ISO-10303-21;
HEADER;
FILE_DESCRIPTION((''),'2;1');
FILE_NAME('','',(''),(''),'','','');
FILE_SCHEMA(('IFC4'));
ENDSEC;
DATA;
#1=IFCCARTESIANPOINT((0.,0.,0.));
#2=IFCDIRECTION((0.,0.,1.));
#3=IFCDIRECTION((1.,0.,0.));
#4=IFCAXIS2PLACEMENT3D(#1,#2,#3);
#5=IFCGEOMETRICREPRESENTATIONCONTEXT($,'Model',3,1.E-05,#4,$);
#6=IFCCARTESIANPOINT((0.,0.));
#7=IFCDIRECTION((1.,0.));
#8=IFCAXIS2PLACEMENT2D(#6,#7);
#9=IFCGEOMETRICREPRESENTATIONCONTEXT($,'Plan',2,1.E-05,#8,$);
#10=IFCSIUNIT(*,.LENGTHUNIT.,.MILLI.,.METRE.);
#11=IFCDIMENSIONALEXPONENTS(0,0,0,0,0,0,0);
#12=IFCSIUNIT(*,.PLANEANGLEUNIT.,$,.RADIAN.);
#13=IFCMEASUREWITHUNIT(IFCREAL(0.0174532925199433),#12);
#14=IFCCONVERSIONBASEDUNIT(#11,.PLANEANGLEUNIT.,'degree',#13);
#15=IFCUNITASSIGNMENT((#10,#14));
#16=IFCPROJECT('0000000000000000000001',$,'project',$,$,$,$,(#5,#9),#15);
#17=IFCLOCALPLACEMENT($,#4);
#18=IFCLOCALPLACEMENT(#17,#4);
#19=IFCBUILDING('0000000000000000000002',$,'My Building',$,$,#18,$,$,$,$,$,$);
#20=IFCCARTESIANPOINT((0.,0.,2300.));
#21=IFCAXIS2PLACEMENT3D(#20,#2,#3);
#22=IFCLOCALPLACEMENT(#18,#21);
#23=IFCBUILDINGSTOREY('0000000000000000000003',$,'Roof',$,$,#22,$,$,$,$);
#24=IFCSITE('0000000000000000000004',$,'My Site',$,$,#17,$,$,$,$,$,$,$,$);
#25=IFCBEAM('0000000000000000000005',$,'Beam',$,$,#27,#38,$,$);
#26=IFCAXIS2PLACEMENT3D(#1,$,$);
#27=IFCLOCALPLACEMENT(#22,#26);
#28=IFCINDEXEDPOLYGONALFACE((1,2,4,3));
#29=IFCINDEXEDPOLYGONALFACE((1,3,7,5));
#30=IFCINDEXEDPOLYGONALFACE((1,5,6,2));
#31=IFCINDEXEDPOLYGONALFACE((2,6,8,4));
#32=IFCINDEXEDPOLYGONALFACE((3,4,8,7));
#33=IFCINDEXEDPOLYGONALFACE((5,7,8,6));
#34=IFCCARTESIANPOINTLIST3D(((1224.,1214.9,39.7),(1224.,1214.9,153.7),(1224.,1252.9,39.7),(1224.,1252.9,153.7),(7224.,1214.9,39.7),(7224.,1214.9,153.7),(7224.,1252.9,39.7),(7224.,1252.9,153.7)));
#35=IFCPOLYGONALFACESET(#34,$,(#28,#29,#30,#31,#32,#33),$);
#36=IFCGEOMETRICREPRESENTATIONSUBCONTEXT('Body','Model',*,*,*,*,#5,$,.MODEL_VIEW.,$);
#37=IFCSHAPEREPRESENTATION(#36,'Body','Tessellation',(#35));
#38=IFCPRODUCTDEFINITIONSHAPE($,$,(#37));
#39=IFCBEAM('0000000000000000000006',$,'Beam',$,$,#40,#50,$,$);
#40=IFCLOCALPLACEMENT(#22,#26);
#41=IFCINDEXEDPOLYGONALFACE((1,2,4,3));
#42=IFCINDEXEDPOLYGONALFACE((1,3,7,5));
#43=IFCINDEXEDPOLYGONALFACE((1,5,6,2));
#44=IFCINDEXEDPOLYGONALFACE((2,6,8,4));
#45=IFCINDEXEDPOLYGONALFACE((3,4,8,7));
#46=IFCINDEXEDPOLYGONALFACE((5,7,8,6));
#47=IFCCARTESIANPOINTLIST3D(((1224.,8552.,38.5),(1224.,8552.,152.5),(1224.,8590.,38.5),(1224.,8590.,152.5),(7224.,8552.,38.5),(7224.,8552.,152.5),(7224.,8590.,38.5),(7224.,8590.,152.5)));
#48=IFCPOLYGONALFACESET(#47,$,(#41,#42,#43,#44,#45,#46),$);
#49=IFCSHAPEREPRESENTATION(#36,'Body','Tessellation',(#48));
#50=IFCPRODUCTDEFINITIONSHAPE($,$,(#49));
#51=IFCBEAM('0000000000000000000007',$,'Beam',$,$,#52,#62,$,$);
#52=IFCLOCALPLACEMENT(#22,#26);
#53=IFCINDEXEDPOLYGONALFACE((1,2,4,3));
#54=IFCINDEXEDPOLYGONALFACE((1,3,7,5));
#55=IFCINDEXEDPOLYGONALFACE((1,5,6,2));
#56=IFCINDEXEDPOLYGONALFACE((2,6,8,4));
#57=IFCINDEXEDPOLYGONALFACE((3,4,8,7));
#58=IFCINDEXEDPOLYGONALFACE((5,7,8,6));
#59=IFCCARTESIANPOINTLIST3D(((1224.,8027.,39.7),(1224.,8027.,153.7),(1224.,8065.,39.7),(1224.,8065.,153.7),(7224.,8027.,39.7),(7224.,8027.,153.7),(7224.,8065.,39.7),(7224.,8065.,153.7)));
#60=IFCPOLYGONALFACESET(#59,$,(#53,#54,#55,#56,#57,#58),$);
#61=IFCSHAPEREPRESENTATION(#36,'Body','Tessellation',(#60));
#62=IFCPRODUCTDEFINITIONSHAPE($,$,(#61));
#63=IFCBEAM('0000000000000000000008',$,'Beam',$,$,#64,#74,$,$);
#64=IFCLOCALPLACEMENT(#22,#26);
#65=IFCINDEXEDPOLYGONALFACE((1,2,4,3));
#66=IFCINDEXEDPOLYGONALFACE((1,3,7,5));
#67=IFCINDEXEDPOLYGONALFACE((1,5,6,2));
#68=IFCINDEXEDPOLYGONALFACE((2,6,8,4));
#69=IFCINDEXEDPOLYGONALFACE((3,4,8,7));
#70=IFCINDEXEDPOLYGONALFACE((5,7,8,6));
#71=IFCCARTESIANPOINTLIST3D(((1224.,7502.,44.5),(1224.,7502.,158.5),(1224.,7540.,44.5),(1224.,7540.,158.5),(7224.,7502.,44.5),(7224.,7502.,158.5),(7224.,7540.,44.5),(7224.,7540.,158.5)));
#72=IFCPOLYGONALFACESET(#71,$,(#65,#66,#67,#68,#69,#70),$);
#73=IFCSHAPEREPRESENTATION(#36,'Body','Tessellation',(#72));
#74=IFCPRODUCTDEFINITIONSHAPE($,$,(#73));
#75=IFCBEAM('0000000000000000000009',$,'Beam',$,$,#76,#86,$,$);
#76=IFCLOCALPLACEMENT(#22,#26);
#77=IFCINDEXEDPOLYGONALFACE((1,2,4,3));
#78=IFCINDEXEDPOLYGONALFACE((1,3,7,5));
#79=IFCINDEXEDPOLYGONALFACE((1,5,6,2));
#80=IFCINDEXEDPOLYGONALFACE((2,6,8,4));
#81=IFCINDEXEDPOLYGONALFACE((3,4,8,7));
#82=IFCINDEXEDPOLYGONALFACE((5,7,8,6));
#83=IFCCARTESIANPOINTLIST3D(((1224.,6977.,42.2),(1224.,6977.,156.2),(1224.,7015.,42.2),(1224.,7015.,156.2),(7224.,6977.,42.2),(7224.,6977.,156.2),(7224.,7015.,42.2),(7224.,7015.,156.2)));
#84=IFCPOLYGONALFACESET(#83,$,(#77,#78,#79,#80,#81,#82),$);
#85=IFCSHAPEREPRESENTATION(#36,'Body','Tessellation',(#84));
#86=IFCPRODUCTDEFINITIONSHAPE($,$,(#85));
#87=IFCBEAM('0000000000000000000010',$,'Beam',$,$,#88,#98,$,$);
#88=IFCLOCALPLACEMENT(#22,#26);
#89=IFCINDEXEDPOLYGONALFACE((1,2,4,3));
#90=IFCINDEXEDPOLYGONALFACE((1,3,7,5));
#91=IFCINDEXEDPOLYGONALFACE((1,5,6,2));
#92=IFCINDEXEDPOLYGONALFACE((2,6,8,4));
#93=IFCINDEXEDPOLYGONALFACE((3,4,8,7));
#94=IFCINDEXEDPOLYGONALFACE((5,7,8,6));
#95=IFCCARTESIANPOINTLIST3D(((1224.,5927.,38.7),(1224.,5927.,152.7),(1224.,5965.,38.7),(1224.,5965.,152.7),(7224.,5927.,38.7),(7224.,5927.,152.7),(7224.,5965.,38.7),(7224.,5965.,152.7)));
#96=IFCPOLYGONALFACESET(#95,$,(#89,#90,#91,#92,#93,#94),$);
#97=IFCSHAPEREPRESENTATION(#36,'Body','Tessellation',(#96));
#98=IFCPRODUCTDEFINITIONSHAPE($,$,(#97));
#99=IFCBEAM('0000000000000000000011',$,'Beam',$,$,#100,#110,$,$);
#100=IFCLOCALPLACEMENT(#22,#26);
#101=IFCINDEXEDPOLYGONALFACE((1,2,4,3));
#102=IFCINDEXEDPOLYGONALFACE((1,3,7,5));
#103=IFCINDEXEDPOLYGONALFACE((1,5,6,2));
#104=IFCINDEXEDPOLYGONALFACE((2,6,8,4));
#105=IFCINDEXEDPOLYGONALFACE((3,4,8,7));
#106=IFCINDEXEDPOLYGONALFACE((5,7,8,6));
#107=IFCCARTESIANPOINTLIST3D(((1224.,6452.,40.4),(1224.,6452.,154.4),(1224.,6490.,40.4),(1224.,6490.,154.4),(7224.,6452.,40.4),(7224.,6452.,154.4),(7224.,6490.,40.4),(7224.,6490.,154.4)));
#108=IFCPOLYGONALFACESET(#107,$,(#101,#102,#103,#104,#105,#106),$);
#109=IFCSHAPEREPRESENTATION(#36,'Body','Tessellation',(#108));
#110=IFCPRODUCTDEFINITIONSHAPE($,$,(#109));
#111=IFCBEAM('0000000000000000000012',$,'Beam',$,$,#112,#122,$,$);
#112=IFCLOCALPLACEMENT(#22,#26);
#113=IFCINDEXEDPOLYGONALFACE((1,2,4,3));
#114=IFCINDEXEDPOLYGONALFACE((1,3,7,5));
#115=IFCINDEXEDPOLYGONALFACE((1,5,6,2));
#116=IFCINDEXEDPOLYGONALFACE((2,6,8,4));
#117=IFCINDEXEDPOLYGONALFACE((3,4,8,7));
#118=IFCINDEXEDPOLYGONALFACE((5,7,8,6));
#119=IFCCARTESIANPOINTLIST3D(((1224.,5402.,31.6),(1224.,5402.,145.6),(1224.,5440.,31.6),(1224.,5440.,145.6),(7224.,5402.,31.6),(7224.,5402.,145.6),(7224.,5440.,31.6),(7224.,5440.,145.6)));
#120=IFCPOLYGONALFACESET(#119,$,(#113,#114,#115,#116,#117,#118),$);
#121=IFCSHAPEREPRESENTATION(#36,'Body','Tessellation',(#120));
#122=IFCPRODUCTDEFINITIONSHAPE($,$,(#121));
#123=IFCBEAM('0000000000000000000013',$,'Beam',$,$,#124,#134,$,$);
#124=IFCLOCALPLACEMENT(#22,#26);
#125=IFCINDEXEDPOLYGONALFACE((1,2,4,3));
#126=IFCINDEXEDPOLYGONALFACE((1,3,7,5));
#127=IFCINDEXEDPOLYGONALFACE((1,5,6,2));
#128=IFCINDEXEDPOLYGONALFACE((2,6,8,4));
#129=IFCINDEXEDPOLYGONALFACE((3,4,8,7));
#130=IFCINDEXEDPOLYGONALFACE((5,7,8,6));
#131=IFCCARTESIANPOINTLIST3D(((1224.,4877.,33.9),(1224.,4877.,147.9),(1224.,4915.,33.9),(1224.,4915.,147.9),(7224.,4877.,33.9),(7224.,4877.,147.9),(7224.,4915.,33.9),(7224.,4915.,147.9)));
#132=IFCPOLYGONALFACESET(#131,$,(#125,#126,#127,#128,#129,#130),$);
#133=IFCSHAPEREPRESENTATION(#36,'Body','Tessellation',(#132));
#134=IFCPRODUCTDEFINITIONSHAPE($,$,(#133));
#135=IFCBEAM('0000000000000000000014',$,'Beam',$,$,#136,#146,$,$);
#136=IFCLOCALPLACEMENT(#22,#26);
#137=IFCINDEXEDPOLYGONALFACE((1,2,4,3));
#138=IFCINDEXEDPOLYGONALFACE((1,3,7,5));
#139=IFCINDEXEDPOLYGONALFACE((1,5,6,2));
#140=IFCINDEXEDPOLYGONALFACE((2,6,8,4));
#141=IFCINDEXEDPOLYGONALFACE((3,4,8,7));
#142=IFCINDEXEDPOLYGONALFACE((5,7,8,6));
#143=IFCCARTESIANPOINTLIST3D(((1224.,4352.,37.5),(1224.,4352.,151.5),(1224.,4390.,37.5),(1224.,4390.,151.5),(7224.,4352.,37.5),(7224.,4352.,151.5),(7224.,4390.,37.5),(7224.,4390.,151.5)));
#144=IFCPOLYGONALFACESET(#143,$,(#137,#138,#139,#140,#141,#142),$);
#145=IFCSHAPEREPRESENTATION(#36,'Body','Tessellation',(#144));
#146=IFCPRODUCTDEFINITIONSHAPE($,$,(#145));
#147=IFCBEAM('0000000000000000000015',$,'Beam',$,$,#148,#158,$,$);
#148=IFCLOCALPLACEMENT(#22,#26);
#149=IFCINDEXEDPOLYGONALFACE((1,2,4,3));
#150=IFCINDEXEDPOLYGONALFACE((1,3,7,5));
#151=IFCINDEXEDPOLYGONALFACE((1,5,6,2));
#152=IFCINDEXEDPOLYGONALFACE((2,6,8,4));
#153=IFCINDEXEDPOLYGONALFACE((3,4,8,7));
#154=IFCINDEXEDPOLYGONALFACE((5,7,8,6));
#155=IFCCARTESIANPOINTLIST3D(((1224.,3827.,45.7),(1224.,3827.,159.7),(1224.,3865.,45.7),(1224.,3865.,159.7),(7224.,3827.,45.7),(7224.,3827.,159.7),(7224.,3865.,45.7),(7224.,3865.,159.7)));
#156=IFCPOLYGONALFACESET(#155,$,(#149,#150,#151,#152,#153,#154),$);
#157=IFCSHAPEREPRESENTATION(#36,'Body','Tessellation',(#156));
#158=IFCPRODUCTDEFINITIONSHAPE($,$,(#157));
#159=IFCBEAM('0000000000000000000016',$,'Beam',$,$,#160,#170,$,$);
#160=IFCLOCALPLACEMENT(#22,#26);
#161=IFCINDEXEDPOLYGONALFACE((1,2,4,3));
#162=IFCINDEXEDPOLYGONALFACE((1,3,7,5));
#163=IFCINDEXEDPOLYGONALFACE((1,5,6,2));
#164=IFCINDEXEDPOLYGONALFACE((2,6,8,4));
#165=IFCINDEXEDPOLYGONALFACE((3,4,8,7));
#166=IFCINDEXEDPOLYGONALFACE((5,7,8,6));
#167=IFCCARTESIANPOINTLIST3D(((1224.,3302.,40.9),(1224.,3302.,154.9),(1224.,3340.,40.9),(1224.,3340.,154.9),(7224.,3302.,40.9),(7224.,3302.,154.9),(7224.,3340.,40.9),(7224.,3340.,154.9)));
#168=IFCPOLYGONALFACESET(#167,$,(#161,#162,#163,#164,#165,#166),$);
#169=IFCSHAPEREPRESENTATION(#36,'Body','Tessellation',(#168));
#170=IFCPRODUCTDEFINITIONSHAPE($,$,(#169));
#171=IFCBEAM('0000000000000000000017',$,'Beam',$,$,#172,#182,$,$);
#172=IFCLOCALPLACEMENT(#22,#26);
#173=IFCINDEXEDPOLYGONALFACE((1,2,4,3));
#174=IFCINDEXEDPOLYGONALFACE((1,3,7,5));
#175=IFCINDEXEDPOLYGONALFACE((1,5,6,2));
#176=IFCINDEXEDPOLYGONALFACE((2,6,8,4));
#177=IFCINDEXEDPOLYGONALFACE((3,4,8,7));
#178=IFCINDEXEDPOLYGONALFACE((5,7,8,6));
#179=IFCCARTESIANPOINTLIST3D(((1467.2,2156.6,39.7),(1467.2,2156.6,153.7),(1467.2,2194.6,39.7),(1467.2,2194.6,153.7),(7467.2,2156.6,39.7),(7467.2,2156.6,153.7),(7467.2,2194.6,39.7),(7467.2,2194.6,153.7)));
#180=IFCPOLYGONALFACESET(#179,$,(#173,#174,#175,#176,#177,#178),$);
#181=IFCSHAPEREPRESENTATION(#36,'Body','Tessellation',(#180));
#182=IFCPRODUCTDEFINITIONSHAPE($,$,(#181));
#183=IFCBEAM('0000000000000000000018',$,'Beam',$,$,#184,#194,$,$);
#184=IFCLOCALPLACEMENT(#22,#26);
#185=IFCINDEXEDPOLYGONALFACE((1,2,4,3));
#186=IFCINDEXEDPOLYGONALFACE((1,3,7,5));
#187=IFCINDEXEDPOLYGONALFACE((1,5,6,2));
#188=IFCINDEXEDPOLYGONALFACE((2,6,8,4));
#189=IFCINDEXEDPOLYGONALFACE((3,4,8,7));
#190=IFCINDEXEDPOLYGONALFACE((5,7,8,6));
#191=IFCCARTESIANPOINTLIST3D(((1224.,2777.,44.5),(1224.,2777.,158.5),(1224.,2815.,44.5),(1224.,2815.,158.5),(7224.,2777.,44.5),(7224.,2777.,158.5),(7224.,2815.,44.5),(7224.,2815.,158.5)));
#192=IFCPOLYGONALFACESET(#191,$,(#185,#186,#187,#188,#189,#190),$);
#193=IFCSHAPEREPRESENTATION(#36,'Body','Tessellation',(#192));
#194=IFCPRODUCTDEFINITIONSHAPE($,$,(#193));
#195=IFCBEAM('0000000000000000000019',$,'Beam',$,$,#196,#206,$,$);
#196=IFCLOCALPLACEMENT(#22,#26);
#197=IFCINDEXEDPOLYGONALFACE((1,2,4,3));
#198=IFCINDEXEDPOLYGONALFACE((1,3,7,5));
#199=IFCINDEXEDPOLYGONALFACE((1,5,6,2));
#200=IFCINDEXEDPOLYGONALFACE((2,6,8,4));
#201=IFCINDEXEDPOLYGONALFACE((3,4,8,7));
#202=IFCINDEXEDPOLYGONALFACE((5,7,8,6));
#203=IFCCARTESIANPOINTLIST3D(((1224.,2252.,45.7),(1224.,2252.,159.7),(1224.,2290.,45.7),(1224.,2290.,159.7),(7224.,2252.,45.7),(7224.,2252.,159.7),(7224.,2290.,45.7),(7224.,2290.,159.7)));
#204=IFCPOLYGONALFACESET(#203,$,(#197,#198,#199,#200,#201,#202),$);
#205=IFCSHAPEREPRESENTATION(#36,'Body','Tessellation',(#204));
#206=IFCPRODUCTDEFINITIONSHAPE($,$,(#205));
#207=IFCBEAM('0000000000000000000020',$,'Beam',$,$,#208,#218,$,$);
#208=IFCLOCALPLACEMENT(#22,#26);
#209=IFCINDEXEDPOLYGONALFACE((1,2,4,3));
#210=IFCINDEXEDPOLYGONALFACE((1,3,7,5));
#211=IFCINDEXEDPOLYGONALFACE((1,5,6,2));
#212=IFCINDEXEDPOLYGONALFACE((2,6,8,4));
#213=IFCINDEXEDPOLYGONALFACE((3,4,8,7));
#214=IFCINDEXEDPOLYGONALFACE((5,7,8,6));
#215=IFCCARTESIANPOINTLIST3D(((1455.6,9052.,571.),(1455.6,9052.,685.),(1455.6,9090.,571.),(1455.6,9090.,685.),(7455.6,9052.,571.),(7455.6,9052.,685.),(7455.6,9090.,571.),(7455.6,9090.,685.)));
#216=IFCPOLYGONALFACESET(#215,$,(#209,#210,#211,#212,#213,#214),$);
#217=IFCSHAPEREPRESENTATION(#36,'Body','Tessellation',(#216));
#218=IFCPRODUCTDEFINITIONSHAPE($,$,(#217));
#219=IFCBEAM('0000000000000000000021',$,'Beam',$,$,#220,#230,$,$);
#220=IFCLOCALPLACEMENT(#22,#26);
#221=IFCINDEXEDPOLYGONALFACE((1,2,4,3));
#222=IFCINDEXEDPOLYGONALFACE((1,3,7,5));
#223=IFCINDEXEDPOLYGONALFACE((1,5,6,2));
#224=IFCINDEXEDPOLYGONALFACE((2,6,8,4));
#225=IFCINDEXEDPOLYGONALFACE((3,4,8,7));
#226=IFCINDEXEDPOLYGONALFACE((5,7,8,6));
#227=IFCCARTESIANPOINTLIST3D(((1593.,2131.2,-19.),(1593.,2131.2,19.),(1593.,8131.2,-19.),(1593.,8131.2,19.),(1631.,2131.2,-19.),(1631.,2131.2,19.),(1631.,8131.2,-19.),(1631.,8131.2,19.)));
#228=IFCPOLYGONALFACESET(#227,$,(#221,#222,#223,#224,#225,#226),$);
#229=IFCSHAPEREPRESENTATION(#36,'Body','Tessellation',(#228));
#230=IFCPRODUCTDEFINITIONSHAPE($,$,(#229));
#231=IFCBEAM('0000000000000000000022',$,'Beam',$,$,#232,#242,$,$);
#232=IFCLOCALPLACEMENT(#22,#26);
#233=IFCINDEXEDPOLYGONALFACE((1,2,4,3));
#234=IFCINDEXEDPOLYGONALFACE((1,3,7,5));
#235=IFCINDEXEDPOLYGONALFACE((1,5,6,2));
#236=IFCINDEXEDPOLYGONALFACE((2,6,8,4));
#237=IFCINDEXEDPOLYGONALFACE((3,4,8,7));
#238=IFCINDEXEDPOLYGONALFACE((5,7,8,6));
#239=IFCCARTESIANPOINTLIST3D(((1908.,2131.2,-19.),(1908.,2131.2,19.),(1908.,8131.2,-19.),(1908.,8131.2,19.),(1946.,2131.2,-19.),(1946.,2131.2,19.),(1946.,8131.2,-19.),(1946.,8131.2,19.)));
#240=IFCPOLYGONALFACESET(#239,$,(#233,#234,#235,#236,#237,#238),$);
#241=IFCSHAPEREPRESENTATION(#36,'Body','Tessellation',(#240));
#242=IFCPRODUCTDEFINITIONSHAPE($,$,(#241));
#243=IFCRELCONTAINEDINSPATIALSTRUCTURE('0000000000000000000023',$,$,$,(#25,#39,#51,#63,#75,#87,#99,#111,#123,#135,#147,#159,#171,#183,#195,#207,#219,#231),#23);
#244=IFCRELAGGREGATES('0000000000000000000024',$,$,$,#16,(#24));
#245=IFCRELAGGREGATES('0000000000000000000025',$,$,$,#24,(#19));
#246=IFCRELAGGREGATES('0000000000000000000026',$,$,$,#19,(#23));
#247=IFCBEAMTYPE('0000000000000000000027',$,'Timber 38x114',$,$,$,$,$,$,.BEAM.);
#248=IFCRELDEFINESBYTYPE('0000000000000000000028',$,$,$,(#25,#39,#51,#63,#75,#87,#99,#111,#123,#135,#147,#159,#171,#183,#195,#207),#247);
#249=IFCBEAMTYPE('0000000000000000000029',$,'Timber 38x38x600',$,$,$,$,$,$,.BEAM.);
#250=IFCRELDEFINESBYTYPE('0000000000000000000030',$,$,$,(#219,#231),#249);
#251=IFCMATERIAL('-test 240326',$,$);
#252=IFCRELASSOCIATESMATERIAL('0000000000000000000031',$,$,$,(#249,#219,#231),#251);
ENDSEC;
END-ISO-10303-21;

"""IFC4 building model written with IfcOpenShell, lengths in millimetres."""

from ifc_helpers import new_model, entity, si_unit, converted_unit, frame, origin_with_axes, origin_2d_with_axis, place, context, subcontext, project, spatial, line, indexed_curve, rectangle, outline, extrude, material, material_profile, profile_set, profile_usage, type_object, element, save


model = new_model("IFC4")

# Units and contexts
model_context = context("Model", 3, precision=1e-05, world=origin_with_axes())
plan_context = context("Plan", 2, precision=1e-05, world=origin_2d_with_axis())
body_context = subcontext(model_context, "Body", "Model", "MODEL_VIEW")
ifc_project = project(units=[si_unit("LENGTHUNIT", "METRE", prefix="MILLI"), converted_unit("PLANEANGLEUNIT", "degree", entity("IfcReal", 0.0174532925199433), si_unit("PLANEANGLEUNIT", "RADIAN"), dimensions=[0, 0, 0, 0, 0, 0, 0])], contexts=[model_context, plan_context])

# Site, building, storey
site_placement = place(None, origin_with_axes())
site = spatial("IfcSite", under=ifc_project, at=site_placement, Name="My Site")
building_placement = place(site_placement, origin_with_axes())
building = spatial("IfcBuilding", under=site, at=building_placement, Name="My Building")
storey_placement = place(building_placement, frame((0.0, 0.0, 2300.0), z_axis=(0.0, 0.0, 1.0), x_axis=(1.0, 0.0, 0.0)))
storey = spatial("IfcBuildingStorey", under=building, at=storey_placement, Name="Roof")

# Beams
beam_type_1 = type_object("IfcBeamType", Name="Timber 38x114", PredefinedType="BEAM")
for number, where, z_axis, x_axis, name in (
    (1, (1224.0, 1214.9, 39.7), (1.0, 0.0, 0.0), (0.0, 1.0, 0.0), "Beam"),
    (2, (1224.0, 8552.0, 38.5), (1.0, 0.0, 0.0), (0.0, 1.0, 0.0), "Beam"),
    (3, (1224.0, 8027.0, 39.7), (1.0, 0.0, 0.0), (0.0, 1.0, 0.0), "Beam"),
    (4, (1224.0, 7502.0, 44.5), (1.0, 0.0, 0.0), (0.0, 1.0, 0.0), "Beam"),
    (5, (1224.0, 6977.0, 42.2), (1.0, 0.0, 0.0), (0.0, 1.0, 0.0), "Beam"),
    (6, (1224.0, 5927.0, 38.7), (1.0, 0.0, 0.0), (0.0, 1.0, 0.0), "Beam"),
    (7, (1224.0, 6452.0, 40.4), (1.0, 0.0, 0.0), (0.0, 1.0, 0.0), "Beam"),
    (8, (1224.0, 5402.0, 31.6), (1.0, 0.0, 0.0), (0.0, 1.0, 0.0), "Beam"),
    (9, (1224.0, 4877.0, 33.9), (1.0, 0.0, 0.0), (0.0, 1.0, 0.0), "Beam"),
    (10, (1224.0, 4352.0, 37.5), (1.0, 0.0, 0.0), (0.0, 1.0, 0.0), "Beam"),
    (11, (1224.0, 3827.0, 45.7), (1.0, 0.0, 0.0), (0.0, 1.0, 0.0), "Beam"),
    (12, (1224.0, 3302.0, 40.9), (1.0, 0.0, 0.0), (0.0, 1.0, 0.0), "Beam"),
    (13, (1467.2, 2156.6, 39.7), (1.0, 0.0, 0.0), (0.0, 1.0, 0.0), "Beam"),
    (14, (1224.0, 2777.0, 44.5), (1.0, 0.0, 0.0), (0.0, 1.0, 0.0), "Beam"),
    (15, (1224.0, 2252.0, 45.7), (1.0, 0.0, 0.0), (0.0, 1.0, 0.0), "Beam"),
    (16, (1455.6, 9052.0, 571.0), (1.0, 0.0, 0.0), (0.0, 1.0, 0.0), "Beam"),
):
    element("IfcBeam", number, at=place(storey_placement, frame(where, z_axis=z_axis, x_axis=x_axis)), inside=storey, type_object=beam_type_1, Name=name, context=body_context, shape_type="SweptSolid", body=[
        extrude(outline(indexed_curve([(0.0, 0.0), (38.0, 0.0), (38.0, 114.0), (0.0, 114.0)], segments=[line(3, 2), line(2, 1), line(1, 4), line(4, 3)], self_intersect=False)), origin_with_axes(), (0.0, 0.0, 1.0), 6000.0),
    ])
ifc_material = material(Name="-test 240326")
ifc_material_profile = material_profile(ifc_material, rectangle(XDim=38.0, YDim=38.0))
ifc_profile_set = profile_set([ifc_material_profile])
ifc_profile_usage_1 = profile_usage(ifc_profile_set, cardinal=5)
beam_type_2 = type_object("IfcBeamType", Name="Timber 38x38x600", PredefinedType="BEAM", material=ifc_profile_set)
beam_1_placement = place(storey_placement, frame((1612.0, 2131.2, 0.0), z_axis=(0.0, 1.0, 0.0), x_axis=(-1.0, 0.0, 0.0)))
element("IfcBeam", 17, at=beam_1_placement, inside=storey, type_object=beam_type_2, material=ifc_profile_usage_1, Name="Beam", context=body_context, shape_type="SweptSolid", body=[
    extrude(rectangle(XDim=38.0, YDim=38.0), origin_with_axes(), (0.0, 0.0, 1.0), 6000.0),
])
ifc_profile_usage_2 = profile_usage(ifc_profile_set, cardinal=5)
beam_2_placement = place(storey_placement, frame((1927.0, 2131.2, 0.0), z_axis=(0.0, 1.0, 0.0), x_axis=(-1.0, 0.0, 0.0)))
element("IfcBeam", 18, at=beam_2_placement, inside=storey, type_object=beam_type_2, material=ifc_profile_usage_2, Name="Beam", context=body_context, shape_type="SweptSolid", body=[
    extrude(rectangle(XDim=38.0, YDim=38.0), origin_with_axes(), (0.0, 0.0, 1.0), 6000.0),
])

save(model, "model.ifc")
